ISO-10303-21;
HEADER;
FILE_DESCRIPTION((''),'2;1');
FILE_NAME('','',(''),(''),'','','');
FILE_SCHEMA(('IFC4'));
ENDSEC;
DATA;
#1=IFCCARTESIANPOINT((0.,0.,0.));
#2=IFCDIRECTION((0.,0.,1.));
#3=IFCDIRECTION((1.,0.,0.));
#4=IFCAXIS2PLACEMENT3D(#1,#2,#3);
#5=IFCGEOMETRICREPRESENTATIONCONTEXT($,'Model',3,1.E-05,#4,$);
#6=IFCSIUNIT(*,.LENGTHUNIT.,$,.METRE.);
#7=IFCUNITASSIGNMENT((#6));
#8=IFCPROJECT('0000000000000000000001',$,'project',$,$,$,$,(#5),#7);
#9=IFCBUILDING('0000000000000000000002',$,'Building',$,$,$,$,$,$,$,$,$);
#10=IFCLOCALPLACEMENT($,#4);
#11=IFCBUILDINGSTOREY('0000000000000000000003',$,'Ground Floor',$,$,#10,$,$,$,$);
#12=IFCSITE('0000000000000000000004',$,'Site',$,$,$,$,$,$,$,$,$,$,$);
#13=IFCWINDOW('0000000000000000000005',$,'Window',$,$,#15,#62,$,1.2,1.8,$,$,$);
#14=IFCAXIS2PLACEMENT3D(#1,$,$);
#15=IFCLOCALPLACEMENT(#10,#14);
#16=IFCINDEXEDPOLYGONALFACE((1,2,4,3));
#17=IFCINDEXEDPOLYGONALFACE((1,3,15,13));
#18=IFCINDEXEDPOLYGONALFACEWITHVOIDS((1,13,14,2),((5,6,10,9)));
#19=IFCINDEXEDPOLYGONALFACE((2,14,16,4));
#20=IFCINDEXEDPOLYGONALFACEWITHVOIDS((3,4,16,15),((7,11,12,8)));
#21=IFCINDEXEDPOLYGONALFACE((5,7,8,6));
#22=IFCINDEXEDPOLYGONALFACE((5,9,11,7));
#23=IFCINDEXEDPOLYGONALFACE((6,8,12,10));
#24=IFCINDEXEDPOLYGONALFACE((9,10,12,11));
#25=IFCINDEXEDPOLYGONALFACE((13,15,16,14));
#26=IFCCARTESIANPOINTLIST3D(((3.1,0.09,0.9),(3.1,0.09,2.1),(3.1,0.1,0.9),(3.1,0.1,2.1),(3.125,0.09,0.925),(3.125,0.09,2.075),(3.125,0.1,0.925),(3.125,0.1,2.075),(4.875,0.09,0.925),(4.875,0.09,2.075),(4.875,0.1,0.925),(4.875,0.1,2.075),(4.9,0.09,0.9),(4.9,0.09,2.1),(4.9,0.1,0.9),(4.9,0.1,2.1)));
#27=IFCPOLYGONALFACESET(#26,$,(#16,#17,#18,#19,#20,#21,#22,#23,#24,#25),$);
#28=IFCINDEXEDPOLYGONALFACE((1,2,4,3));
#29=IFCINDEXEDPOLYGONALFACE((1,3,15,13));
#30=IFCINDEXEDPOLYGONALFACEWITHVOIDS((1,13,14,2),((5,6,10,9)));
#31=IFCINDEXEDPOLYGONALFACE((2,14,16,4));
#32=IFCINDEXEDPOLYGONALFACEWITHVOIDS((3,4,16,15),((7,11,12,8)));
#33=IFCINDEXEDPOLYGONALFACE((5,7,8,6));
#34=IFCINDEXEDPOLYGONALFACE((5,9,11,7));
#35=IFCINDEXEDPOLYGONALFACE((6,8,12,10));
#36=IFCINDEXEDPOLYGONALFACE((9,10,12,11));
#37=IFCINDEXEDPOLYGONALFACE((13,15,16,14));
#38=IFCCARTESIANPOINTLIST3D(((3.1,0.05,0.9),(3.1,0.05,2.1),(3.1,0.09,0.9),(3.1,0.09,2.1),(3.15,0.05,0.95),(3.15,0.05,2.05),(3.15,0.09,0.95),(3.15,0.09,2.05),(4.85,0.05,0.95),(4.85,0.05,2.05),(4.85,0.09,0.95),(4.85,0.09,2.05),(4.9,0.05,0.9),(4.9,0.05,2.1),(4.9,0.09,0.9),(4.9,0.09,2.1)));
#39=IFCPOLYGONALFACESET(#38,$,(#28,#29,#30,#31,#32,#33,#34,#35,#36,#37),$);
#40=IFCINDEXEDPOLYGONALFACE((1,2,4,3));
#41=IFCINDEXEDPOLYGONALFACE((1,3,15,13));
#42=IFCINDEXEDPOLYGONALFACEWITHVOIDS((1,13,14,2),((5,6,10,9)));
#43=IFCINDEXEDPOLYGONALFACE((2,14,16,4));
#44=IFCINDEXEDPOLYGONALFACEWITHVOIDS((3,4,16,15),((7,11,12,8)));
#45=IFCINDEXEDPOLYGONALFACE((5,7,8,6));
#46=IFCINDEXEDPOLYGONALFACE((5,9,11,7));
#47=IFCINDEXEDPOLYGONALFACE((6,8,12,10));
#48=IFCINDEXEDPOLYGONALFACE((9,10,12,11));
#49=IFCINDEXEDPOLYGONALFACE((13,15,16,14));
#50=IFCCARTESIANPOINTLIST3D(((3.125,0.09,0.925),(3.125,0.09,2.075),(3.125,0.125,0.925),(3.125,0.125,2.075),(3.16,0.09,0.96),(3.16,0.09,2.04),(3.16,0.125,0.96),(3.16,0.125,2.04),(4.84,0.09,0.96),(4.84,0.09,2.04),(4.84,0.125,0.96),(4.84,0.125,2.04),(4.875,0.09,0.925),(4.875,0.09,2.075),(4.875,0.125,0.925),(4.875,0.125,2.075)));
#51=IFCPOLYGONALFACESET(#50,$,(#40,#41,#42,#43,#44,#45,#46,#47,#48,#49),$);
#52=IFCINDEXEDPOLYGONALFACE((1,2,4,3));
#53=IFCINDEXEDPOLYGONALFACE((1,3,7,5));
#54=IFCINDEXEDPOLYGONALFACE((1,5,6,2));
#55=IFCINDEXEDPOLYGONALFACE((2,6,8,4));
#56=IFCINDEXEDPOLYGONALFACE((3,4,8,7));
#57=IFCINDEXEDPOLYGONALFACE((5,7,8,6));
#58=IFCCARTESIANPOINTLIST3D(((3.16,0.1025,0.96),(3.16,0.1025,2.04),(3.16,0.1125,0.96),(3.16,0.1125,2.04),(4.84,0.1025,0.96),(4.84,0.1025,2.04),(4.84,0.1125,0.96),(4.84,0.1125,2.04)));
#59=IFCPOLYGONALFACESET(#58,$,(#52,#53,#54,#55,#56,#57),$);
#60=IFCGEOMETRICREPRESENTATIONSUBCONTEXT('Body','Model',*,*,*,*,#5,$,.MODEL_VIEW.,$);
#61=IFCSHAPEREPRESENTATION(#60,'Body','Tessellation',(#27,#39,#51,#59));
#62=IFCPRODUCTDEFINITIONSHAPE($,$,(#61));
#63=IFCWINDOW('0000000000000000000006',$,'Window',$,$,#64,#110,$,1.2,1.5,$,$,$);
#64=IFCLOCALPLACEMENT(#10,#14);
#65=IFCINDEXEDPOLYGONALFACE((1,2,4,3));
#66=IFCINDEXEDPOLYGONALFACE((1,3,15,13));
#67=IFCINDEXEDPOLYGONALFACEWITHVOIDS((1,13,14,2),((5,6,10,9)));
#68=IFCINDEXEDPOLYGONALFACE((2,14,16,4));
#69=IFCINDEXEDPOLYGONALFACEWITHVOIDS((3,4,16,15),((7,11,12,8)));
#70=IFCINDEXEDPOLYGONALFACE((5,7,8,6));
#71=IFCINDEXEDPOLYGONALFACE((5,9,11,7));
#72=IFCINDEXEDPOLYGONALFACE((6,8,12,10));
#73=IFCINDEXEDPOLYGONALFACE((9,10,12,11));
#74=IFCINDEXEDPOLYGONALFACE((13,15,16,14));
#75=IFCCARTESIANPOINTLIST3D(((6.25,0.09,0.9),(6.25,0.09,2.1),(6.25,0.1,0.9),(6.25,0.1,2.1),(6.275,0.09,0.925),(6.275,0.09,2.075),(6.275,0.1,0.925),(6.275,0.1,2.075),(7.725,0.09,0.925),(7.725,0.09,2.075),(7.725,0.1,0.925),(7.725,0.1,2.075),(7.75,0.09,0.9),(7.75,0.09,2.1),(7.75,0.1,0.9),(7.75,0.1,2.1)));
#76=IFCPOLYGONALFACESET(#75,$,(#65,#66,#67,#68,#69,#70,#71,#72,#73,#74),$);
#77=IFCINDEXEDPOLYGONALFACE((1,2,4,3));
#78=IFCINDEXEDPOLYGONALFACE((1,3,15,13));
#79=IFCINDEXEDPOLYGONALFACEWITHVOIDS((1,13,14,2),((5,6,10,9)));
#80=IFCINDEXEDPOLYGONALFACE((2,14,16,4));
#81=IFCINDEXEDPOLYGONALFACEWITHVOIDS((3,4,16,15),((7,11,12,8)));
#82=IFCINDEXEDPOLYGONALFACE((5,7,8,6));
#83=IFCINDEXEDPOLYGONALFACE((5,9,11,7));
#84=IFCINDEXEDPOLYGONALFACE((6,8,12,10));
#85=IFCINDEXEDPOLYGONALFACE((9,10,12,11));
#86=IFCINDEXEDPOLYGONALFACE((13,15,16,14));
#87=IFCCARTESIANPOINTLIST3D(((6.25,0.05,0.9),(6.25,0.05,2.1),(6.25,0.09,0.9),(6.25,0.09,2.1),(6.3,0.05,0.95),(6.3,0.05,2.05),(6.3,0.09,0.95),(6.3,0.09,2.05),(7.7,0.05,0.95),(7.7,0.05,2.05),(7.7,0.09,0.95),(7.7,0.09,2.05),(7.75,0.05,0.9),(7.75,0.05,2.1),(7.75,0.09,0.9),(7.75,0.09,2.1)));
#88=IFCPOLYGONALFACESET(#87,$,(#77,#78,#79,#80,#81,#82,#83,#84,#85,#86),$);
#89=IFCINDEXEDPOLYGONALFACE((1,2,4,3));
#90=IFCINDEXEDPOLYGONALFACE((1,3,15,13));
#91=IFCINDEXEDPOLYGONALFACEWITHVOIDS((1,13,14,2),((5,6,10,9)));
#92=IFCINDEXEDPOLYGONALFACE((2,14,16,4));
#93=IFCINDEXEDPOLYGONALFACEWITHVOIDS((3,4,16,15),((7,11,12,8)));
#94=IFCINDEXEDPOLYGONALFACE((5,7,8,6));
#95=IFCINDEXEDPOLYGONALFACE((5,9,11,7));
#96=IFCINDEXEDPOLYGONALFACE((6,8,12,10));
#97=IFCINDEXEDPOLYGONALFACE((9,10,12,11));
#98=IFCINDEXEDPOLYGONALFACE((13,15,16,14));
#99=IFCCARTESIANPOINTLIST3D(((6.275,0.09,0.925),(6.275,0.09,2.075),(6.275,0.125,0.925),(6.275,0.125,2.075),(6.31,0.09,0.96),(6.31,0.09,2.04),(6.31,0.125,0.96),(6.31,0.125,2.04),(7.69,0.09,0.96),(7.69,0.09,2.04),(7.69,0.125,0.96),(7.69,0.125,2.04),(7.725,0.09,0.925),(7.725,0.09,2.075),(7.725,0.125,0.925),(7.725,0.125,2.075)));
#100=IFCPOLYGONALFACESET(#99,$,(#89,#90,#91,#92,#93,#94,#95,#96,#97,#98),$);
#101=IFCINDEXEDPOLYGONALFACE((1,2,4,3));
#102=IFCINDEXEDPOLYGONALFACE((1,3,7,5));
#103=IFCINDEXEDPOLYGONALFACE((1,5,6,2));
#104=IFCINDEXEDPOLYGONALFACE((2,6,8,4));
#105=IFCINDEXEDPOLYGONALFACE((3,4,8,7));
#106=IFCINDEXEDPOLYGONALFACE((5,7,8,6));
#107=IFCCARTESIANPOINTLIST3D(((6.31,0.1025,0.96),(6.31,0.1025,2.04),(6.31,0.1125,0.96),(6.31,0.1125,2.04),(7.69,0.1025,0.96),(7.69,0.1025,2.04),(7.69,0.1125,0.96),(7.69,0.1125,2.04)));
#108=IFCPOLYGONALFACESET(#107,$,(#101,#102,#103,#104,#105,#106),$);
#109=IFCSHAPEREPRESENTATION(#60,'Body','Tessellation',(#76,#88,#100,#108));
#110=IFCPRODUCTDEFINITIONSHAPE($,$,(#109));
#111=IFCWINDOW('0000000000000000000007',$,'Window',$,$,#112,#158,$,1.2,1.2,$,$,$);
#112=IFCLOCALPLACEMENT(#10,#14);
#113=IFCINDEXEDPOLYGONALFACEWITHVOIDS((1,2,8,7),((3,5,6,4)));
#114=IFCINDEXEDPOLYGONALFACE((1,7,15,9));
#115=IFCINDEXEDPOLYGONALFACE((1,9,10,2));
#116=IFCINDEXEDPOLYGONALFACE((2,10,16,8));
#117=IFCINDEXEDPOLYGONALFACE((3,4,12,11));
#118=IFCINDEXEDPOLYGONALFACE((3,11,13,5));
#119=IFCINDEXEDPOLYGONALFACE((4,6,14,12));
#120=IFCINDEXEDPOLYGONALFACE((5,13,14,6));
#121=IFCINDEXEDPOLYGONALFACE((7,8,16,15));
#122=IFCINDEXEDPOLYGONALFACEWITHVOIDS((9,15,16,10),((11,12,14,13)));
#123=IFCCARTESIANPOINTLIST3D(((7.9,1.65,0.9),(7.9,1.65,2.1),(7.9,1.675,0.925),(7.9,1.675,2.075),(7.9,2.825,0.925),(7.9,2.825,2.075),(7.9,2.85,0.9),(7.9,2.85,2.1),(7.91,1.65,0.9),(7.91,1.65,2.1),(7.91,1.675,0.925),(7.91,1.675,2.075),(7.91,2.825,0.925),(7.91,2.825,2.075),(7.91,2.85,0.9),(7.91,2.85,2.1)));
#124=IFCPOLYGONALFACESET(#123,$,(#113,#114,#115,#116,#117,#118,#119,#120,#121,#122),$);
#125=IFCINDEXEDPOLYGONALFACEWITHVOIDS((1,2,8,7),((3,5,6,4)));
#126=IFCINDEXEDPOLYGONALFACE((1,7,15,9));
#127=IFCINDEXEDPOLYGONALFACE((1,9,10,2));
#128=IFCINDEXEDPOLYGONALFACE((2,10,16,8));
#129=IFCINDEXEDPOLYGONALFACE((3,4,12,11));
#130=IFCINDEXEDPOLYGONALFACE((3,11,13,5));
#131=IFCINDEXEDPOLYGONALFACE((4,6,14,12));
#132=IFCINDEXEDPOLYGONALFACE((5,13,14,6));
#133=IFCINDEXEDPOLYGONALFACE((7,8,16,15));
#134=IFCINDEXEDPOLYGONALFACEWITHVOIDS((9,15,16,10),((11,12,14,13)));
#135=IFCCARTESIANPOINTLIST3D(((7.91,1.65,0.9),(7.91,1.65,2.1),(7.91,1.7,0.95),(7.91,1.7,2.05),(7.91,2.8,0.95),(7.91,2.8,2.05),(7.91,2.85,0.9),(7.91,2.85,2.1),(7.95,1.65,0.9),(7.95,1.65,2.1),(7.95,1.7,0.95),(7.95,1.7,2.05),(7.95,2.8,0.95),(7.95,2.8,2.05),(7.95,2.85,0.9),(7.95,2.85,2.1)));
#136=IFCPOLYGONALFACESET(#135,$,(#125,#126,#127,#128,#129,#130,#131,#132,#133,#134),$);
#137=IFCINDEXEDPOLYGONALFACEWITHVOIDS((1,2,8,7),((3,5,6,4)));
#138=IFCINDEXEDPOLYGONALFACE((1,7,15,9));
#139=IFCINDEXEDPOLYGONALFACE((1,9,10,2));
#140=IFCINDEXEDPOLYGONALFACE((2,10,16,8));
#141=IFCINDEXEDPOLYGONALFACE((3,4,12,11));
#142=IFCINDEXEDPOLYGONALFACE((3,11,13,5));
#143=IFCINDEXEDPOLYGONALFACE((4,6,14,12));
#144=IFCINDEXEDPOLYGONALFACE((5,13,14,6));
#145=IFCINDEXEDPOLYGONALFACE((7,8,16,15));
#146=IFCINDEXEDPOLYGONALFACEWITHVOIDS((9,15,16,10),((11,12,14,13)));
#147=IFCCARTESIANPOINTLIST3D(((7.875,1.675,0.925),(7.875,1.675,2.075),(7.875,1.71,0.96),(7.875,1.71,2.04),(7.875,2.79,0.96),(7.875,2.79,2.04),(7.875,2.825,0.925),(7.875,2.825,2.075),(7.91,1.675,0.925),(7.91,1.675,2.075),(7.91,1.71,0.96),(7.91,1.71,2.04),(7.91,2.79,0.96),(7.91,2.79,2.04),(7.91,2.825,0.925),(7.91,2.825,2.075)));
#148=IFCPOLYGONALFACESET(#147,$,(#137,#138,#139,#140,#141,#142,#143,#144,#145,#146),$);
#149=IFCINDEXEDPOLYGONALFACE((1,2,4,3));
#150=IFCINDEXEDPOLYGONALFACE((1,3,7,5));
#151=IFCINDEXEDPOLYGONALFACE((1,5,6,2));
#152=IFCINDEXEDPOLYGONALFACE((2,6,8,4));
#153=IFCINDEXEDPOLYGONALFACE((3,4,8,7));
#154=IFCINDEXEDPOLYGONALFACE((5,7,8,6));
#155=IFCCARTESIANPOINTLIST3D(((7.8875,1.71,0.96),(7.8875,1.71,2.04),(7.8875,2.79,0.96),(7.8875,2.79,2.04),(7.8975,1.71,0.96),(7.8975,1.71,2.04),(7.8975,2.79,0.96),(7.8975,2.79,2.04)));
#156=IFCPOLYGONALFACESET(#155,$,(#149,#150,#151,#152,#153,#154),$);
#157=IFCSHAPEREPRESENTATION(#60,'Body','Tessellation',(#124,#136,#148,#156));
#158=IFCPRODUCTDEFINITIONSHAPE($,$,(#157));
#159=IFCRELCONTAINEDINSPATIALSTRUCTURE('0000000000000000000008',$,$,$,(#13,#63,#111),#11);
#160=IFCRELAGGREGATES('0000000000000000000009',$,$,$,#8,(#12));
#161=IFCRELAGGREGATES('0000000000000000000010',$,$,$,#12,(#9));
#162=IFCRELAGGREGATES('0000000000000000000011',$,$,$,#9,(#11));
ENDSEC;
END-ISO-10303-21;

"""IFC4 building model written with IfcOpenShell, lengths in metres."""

from ifc_helpers import new_model, si_unit, frame, origin_with_axes, place, context, subcontext, project, spatial, line, indexed_curve, outline, extrude, element, save


model = new_model("IFC4")

# Units and contexts
model_context = context("Model", 3, precision=1e-05, world=origin_with_axes())
body_context = subcontext(model_context, "Body", "Model", "MODEL_VIEW")
ifc_project = project(units=[si_unit("LENGTHUNIT", "METRE")], contexts=[model_context])

# Site, building, storey
site = spatial("IfcSite", under=ifc_project, Name="Site")
building = spatial("IfcBuilding", under=site, Name="Building")
storey_placement = place(None, origin_with_axes())
storey = spatial("IfcBuildingStorey", under=building, at=storey_placement, Name="Ground Floor")

# Windows
window_1_placement = place(storey_placement, frame((3.1, 0.0, 0.9), z_axis=(0.0, 0.0, 1.0), x_axis=(1.0, 0.0, 0.0)))
element("IfcWindow", 1, at=window_1_placement, inside=storey, Name="Window", OverallHeight=1.2, OverallWidth=1.8, context=body_context, shape_type="SweptSolid", body=[
    extrude(outline(indexed_curve([(0.0, 0.0), (1.8, 0.0), (1.8, 1.2), (0.0, 1.2)], segments=[line(1, 2, 3, 4, 1)]), holes=[indexed_curve([(0.025, 0.025), (1.775, 0.025), (1.775, 1.175), (0.025, 1.175)], segments=[line(1, 2, 3, 4, 1)])]), frame((0.0, 0.09, 0.0), z_axis=(0.0, -1.0, 0.0), x_axis=(1.0, 0.0, 0.0)), (0.0, 0.0, -1.0), 0.01),
    extrude(outline(indexed_curve([(0.0, 0.0), (1.8, 0.0), (1.8, 1.2), (0.0, 1.2)], segments=[line(1, 2, 3, 4, 1)]), holes=[indexed_curve([(0.05, 0.05), (1.75, 0.05), (1.75, 1.15), (0.05, 1.15)], segments=[line(1, 2, 3, 4, 1)])]), frame((0.0, 0.05, 0.0), z_axis=(0.0, -1.0, 0.0), x_axis=(1.0, 0.0, 0.0)), (0.0, 0.0, -1.0), 0.04),
    extrude(outline(indexed_curve([(0.0, 0.0), (1.75, 0.0), (1.75, 1.15), (0.0, 1.15)], segments=[line(1, 2, 3, 4, 1)]), holes=[indexed_curve([(0.035, 0.035), (1.715, 0.035), (1.715, 1.115), (0.035, 1.115)], segments=[line(1, 2, 3, 4, 1)])]), frame((0.025, 0.09, 0.025), z_axis=(0.0, -1.0, 0.0), x_axis=(1.0, 0.0, 0.0)), (0.0, 0.0, -1.0), 0.035),
    extrude(outline(indexed_curve([(0.035, 0.035), (1.715, 0.035), (1.715, 1.115), (0.035, 1.115)], segments=[line(1, 2, 3, 4, 1)])), frame((0.025, 0.1025, 0.025), z_axis=(0.0, -1.0, 0.0), x_axis=(1.0, 0.0, 0.0)), (0.0, 0.0, -1.0), 0.01),
])
window_2_placement = place(storey_placement, frame((6.25, 0.0, 0.9), z_axis=(0.0, 0.0, 1.0), x_axis=(1.0, 0.0, 0.0)))
element("IfcWindow", 2, at=window_2_placement, inside=storey, Name="Window", OverallHeight=1.2, OverallWidth=1.5, context=body_context, shape_type="SweptSolid", body=[
    extrude(outline(indexed_curve([(0.0, 0.0), (1.5, 0.0), (1.5, 1.2), (0.0, 1.2)], segments=[line(1, 2, 3, 4, 1)]), holes=[indexed_curve([(0.025, 0.025), (1.475, 0.025), (1.475, 1.175), (0.025, 1.175)], segments=[line(1, 2, 3, 4, 1)])]), frame((0.0, 0.09, 0.0), z_axis=(0.0, -1.0, 0.0), x_axis=(1.0, 0.0, 0.0)), (0.0, 0.0, -1.0), 0.01),
    extrude(outline(indexed_curve([(0.0, 0.0), (1.5, 0.0), (1.5, 1.2), (0.0, 1.2)], segments=[line(1, 2, 3, 4, 1)]), holes=[indexed_curve([(0.05, 0.05), (1.45, 0.05), (1.45, 1.15), (0.05, 1.15)], segments=[line(1, 2, 3, 4, 1)])]), frame((0.0, 0.05, 0.0), z_axis=(0.0, -1.0, 0.0), x_axis=(1.0, 0.0, 0.0)), (0.0, 0.0, -1.0), 0.04),
    extrude(outline(indexed_curve([(0.0, 0.0), (1.45, 0.0), (1.45, 1.15), (0.0, 1.15)], segments=[line(1, 2, 3, 4, 1)]), holes=[indexed_curve([(0.035, 0.035), (1.415, 0.035), (1.415, 1.115), (0.035, 1.115)], segments=[line(1, 2, 3, 4, 1)])]), frame((0.025, 0.09, 0.025), z_axis=(0.0, -1.0, 0.0), x_axis=(1.0, 0.0, 0.0)), (0.0, 0.0, -1.0), 0.035),
    extrude(outline(indexed_curve([(0.035, 0.035), (1.415, 0.035), (1.415, 1.115), (0.035, 1.115)], segments=[line(1, 2, 3, 4, 1)])), frame((0.025, 0.1025, 0.025), z_axis=(0.0, -1.0, 0.0), x_axis=(1.0, 0.0, 0.0)), (0.0, 0.0, -1.0), 0.01),
])
window_3_placement = place(storey_placement, frame((8.0, 1.65, 0.9), z_axis=(0.0, 0.0, 1.0), x_axis=(0.0, 1.0, 0.0)))
element("IfcWindow", 3, at=window_3_placement, inside=storey, Name="Window", OverallHeight=1.2, OverallWidth=1.2, context=body_context, shape_type="SweptSolid", body=[
    extrude(outline(indexed_curve([(0.0, 0.0), (1.2, 0.0), (1.2, 1.2), (0.0, 1.2)], segments=[line(1, 2, 3, 4, 1)]), holes=[indexed_curve([(0.025, 0.025), (1.175, 0.025), (1.175, 1.175), (0.025, 1.175)], segments=[line(1, 2, 3, 4, 1)])]), frame((0.0, 0.09, 0.0), z_axis=(0.0, -1.0, 0.0), x_axis=(1.0, 0.0, 0.0)), (0.0, 0.0, -1.0), 0.01),
    extrude(outline(indexed_curve([(0.0, 0.0), (1.2, 0.0), (1.2, 1.2), (0.0, 1.2)], segments=[line(1, 2, 3, 4, 1)]), holes=[indexed_curve([(0.05, 0.05), (1.15, 0.05), (1.15, 1.15), (0.05, 1.15)], segments=[line(1, 2, 3, 4, 1)])]), frame((0.0, 0.05, 0.0), z_axis=(0.0, -1.0, 0.0), x_axis=(1.0, 0.0, 0.0)), (0.0, 0.0, -1.0), 0.04),
    extrude(outline(indexed_curve([(0.0, 0.0), (1.15, 0.0), (1.15, 1.15), (0.0, 1.15)], segments=[line(1, 2, 3, 4, 1)]), holes=[indexed_curve([(0.035, 0.035), (1.115, 0.035), (1.115, 1.115), (0.035, 1.115)], segments=[line(1, 2, 3, 4, 1)])]), frame((0.025, 0.09, 0.025), z_axis=(0.0, -1.0, 0.0), x_axis=(1.0, 0.0, 0.0)), (0.0, 0.0, -1.0), 0.035),
    extrude(outline(indexed_curve([(0.035, 0.035), (1.115, 0.035), (1.115, 1.115), (0.035, 1.115)], segments=[line(1, 2, 3, 4, 1)])), frame((0.025, 0.1025, 0.025), z_axis=(0.0, -1.0, 0.0), x_axis=(1.0, 0.0, 0.0)), (0.0, 0.0, -1.0), 0.01),
])

save(model, "model.ifc")
